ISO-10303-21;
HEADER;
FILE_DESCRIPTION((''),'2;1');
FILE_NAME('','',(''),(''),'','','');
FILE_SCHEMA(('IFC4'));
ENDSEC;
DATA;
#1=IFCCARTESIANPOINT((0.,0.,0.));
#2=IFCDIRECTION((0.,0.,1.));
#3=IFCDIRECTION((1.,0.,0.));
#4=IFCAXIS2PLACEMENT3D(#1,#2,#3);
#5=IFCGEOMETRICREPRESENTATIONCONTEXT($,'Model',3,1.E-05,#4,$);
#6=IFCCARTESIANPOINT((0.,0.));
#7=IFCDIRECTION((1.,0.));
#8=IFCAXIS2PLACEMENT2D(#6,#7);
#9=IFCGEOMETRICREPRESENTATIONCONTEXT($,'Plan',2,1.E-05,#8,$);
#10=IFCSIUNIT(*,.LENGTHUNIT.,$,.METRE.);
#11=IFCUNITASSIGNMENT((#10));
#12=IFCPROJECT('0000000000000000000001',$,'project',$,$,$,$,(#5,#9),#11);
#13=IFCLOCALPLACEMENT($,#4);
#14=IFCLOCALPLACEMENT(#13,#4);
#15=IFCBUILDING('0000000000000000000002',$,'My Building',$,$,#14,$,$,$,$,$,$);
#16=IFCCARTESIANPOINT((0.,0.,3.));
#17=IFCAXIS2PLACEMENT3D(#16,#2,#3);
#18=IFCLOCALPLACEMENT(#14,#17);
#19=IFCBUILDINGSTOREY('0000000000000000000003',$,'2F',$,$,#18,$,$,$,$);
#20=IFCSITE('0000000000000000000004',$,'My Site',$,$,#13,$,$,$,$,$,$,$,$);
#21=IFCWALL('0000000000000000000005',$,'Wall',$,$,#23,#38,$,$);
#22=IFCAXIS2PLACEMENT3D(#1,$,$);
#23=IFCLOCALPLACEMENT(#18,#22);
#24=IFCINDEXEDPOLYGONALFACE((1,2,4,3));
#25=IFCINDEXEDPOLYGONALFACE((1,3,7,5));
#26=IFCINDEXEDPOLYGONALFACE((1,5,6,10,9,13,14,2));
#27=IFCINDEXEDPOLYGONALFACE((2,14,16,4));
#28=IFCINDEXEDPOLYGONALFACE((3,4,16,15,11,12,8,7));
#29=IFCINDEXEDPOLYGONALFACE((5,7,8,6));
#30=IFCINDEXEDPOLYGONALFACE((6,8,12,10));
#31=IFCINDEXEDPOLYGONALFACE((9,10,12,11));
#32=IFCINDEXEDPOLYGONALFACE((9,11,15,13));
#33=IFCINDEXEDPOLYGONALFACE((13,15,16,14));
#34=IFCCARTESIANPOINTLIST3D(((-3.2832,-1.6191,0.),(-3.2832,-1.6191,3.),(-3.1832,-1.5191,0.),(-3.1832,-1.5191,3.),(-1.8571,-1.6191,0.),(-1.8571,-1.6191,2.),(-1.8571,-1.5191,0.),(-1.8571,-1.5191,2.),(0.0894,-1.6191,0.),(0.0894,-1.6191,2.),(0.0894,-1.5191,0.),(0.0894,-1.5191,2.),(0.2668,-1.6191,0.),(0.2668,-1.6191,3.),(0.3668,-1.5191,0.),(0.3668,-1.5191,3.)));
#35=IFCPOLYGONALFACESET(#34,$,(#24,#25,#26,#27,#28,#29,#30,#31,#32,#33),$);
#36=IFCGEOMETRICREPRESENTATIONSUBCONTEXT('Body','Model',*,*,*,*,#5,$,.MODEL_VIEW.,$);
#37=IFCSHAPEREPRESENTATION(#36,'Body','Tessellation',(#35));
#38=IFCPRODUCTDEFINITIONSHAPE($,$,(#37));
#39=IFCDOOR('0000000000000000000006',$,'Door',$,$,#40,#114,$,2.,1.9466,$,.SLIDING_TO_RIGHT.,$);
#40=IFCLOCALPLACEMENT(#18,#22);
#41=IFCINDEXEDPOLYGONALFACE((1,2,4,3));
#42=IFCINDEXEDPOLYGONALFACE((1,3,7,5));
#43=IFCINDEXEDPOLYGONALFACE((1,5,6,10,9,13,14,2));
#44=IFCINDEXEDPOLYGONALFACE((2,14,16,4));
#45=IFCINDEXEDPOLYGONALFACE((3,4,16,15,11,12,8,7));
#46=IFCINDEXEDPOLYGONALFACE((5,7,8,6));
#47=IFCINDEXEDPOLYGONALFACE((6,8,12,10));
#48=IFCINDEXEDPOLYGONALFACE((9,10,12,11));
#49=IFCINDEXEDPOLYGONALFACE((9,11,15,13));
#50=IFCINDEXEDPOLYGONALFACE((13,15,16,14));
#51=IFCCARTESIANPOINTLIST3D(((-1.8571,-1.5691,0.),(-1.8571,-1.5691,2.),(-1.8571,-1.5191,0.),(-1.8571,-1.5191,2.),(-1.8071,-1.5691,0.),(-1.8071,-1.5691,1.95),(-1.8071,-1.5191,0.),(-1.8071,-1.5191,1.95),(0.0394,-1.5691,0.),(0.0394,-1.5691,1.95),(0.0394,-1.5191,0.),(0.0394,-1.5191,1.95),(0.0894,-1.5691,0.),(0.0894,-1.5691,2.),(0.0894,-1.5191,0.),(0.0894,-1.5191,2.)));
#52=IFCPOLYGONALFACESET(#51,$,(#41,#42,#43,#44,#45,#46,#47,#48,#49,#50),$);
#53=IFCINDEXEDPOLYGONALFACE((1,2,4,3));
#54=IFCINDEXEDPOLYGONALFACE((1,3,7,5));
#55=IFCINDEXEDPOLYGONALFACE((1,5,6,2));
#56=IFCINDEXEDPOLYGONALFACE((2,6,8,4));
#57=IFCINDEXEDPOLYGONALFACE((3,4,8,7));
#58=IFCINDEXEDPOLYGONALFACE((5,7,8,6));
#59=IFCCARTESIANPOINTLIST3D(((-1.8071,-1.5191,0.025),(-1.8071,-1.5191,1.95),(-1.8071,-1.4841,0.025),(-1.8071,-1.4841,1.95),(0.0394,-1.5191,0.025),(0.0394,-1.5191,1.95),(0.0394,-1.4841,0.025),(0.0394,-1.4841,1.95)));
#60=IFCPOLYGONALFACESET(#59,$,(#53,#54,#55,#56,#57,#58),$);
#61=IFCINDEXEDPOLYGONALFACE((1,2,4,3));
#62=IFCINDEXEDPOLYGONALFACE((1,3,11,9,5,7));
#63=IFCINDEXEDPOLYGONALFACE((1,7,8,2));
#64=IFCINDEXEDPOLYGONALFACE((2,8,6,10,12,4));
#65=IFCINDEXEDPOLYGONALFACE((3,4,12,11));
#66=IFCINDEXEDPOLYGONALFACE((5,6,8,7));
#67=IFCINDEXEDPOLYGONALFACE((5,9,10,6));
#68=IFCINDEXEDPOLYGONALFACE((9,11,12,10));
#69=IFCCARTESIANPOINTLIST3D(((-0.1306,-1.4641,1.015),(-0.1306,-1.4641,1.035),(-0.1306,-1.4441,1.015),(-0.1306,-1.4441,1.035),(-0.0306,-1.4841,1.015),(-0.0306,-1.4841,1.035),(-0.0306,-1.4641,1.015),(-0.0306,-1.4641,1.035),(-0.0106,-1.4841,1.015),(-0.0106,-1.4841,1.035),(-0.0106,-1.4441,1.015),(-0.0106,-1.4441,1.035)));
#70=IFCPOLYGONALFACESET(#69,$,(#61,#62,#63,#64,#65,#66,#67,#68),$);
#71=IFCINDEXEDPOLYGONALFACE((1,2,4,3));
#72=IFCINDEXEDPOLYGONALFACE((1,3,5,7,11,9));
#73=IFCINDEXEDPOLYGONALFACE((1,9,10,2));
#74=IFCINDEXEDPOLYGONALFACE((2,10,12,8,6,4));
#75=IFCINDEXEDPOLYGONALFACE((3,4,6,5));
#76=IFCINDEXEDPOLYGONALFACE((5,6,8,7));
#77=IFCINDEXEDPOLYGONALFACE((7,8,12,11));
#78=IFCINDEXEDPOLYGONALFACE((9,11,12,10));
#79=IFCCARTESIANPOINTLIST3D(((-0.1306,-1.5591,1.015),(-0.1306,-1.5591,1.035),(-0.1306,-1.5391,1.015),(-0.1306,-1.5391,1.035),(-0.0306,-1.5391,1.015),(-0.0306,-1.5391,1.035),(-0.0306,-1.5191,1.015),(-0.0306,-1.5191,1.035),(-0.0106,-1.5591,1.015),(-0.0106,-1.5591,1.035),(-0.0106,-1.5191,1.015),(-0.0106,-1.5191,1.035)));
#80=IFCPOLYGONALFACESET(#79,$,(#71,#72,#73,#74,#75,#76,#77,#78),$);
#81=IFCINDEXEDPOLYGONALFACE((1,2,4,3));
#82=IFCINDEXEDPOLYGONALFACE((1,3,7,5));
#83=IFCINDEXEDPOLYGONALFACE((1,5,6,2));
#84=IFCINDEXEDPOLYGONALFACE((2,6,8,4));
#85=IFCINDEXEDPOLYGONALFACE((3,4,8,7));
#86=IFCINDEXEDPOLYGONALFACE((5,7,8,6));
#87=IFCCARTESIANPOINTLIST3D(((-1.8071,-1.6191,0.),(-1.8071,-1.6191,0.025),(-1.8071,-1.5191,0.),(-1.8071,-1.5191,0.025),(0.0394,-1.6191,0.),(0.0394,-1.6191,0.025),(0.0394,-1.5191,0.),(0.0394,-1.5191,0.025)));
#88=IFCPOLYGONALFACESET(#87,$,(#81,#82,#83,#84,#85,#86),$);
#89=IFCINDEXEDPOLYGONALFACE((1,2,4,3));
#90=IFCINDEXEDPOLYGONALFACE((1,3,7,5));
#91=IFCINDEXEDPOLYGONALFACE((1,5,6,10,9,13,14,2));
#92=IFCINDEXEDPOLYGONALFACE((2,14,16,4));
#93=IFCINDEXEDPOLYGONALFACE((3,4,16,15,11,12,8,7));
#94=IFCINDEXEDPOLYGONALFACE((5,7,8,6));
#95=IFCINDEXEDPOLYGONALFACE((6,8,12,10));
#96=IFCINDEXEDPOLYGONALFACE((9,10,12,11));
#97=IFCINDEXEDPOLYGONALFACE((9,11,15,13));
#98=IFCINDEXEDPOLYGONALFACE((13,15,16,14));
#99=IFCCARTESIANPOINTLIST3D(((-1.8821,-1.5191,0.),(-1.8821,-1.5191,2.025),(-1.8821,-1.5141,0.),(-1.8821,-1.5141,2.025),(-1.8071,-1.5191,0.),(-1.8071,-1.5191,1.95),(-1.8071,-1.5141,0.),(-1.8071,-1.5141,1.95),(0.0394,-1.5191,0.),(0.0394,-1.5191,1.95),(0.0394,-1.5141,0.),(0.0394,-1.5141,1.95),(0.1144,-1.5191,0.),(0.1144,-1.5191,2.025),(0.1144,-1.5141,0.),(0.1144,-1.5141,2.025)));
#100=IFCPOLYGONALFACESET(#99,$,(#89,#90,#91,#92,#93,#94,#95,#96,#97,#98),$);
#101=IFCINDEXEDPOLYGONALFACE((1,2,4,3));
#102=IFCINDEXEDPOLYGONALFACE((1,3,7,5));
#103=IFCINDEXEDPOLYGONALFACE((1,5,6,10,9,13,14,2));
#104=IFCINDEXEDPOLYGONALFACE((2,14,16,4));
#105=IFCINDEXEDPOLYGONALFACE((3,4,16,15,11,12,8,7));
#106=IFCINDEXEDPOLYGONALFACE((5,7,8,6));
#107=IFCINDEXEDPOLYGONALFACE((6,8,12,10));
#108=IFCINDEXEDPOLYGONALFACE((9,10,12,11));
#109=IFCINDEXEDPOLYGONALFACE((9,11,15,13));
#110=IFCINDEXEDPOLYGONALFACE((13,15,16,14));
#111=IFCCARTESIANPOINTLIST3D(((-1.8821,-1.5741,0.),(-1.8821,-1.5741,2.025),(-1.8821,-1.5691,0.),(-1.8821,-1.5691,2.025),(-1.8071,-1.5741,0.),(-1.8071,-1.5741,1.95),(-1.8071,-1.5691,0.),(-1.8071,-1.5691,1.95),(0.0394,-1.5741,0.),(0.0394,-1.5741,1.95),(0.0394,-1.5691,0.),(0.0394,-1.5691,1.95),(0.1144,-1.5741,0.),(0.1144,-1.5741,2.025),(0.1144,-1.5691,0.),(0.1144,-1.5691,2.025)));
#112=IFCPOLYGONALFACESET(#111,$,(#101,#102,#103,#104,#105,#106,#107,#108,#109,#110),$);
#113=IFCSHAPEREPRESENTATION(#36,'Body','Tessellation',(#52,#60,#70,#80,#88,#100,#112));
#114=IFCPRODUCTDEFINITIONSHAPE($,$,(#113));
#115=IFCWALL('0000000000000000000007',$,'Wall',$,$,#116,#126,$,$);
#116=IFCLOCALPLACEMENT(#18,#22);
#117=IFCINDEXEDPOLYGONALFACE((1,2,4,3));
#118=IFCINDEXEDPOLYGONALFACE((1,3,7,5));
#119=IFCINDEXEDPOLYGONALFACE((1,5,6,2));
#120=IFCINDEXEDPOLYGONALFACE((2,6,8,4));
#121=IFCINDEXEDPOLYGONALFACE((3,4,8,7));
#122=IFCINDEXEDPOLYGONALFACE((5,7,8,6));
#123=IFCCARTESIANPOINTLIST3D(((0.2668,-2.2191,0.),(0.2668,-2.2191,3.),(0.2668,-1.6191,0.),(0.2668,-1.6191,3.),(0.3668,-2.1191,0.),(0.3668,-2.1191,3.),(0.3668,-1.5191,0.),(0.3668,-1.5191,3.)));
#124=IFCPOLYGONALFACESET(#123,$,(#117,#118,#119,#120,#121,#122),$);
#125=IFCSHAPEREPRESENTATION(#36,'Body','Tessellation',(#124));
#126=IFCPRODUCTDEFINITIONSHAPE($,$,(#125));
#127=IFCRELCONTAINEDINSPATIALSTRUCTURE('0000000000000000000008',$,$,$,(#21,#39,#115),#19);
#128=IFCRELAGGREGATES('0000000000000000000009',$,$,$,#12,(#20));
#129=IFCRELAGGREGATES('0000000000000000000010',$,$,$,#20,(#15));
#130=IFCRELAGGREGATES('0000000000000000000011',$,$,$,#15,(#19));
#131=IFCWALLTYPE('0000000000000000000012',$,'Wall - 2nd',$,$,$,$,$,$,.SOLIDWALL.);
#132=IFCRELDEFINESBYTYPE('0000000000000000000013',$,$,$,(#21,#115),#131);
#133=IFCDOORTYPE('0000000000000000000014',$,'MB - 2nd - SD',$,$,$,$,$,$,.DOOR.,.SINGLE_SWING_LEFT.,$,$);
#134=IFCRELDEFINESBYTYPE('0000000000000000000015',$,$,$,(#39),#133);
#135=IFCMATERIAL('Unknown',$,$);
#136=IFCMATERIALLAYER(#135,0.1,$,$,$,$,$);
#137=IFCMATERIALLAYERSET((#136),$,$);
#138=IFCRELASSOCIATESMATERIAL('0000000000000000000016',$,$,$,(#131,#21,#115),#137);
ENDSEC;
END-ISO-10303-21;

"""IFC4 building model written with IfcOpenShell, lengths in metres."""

from ifc_helpers import new_model, entity, si_unit, frame, origin_with_axes, origin_2d_with_axis, place, context, subcontext, project, spatial, line, indexed_curve, outline, extrude, shape, source, transform, mapped, material, layer, layer_set, layer_usage, type_object, type_shapes, element, fill, save


model = new_model("IFC4")

# Units and contexts
model_context = context("Model", 3, precision=1e-05, world=origin_with_axes())
plan_context = context("Plan", 2, precision=1e-05, world=origin_2d_with_axis())
body_context_1 = subcontext(model_context, "Body", "Model", "MODEL_VIEW")
body_context_2 = subcontext(plan_context, "Body", "Plan", "PLAN_VIEW")
ifc_project = project(units=[si_unit("LENGTHUNIT", "METRE")], contexts=[model_context, plan_context])

# Site, building, storey
site_placement = place(None, origin_with_axes())
site = spatial("IfcSite", under=ifc_project, at=site_placement, Name="My Site")
building_placement = place(site_placement, origin_with_axes())
building = spatial("IfcBuilding", under=site, at=building_placement, Name="My Building")
storey_placement = place(building_placement, frame((0.0, 0.0, 3.0), z_axis=(0.0, 0.0, 1.0), x_axis=(1.0, 0.0, 0.0)))
storey = spatial("IfcBuildingStorey", under=building, at=storey_placement, Name="2F")

# Shared definitions
ifc_material = material(Name="Unknown")

# Shared definitions
ifc_layer_1 = layer(ifc_material, 0.1)
ifc_layer_set_1 = layer_set([ifc_layer_1])
wall_type = type_object("IfcWallType", Name="Wall - 2nd", PredefinedType="SOLIDWALL", material=ifc_layer_set_1)

# Wall, opening, door
ifc_layer_usage_1 = layer_usage(ifc_layer_set_1, "AXIS2", "POSITIVE", 0.0)
wall_1_placement = place(storey_placement, frame((-3.2832, -1.6191, 0.0), z_axis=(0.0, 0.0, 1.0), x_axis=(1.0, 0.0, 0.0)))
wall_1 = element("IfcWall", 1, at=wall_1_placement, inside=storey, type_object=wall_type, material=ifc_layer_usage_1, Name="Wall", context=body_context_1, shape_type="SweptSolid", body=[
    extrude(outline(indexed_curve([(0.0, 0.0), (0.1, 0.1), (3.65, 0.1), (3.55, 0.0)], segments=[line(1, 2, 3, 4, 1)])), origin_with_axes(), (0.0, 0.0, 1.0), 3.0),
])
shared_shape_1 = source(origin_with_axes(), body_context_1, "Body", "SweptSolid", [
    extrude(outline(indexed_curve([(0.0, 0.0), (1.9466, 0.0), (1.9466, 2.0), (0.0, 2.0)], segments=[line(1, 2, 3, 4, 1)])), frame((0.0, -0.6, 0.0), z_axis=(0.0, -1.0, 0.0), x_axis=(1.0, 0.0, 0.0)), (0.0, 0.0, -1.0), 1.2),
])
opening_1_placement = place(wall_1_placement, frame((3.3726, 0.1, 0.0), z_axis=(0.0, 0.0, 1.0), x_axis=(-1.0, 0.0, 0.0)))
opening_1 = element("IfcOpeningElement", 2, at=opening_1_placement, cuts=wall_1, PredefinedType="OPENING", context=body_context_1, shape_type="MappedRepresentation", body=[
    mapped(shared_shape_1, transform((0.0, 0.0, 0.0), x_axis=(1.0, 0.0, 0.0), y_axis=(0.0, 1.0, 0.0), z_axis=(0.0, 0.0, 1.0), scale=1.0)),
])
door_type_1 = type_object("IfcDoorType", Name="MB - 2nd - SD", OperationType="SINGLE_SWING_LEFT", PredefinedType="DOOR")
shared_shape_2 = source(origin_with_axes(), body_context_1, "Body", "SweptSolid", [
    extrude(outline(indexed_curve([(0.0, 0.0), (0.0, 2.0), (1.9466, 2.0), (1.9466, 0.0), (1.8966, 0.0), (1.8966, 1.95), (0.05, 1.95), (0.05, 0.0)], segments=[line(1, 2, 3, 4, 5, 6, 7, 8, 1)])), frame((0.0, 0.0, 0.0), z_axis=(0.0, -1.0, 0.0), x_axis=(1.0, 0.0, 0.0)), (0.0, 0.0, -1.0), 0.05),
    extrude(outline(indexed_curve([(0.0, 0.0), (1.8466, 0.0), (1.8466, 0.035), (0.0, 0.035)], segments=[line(1, 2, 3, 4, 1)])), frame((0.05, -0.035, 0.025), z_axis=(0.0, 0.0, 1.0), x_axis=(1.0, 0.0, 0.0)), (0.0, 0.0, 1.0), 1.925),
    extrude(outline(indexed_curve([(0.0, 0.0), (0.0, -0.04), (0.12, -0.04), (0.12, -0.02), (0.02, -0.02), (0.02, 0.0)], segments=[line(1, 2, 3, 4, 5, 6, 1)])), frame((0.1, -0.035, 1.015), z_axis=(0.0, 0.0, 1.0), x_axis=(1.0, 0.0, 0.0)), (0.0, 0.0, 1.0), 0.02),
    extrude(outline(indexed_curve([(0.0, 0.0), (0.0, 0.04), (0.12, 0.04), (0.12, 0.02), (0.02, 0.02), (0.02, 0.0)], segments=[line(1, 2, 3, 4, 5, 6, 1)])), frame((0.1, 0.0, 1.015), z_axis=(0.0, 0.0, 1.0), x_axis=(1.0, 0.0, 0.0)), (0.0, 0.0, 1.0), 0.02),
    extrude(outline(indexed_curve([(0.0, 0.0), (1.8466, 0.0), (1.8466, 0.1), (0.0, 0.1)], segments=[line(1, 2, 3, 4, 1)])), frame((0.05, 0.0, 0.0), z_axis=(0.0, 0.0, 1.0), x_axis=(1.0, 0.0, 0.0)), (0.0, 0.0, 1.0), 0.025),
    extrude(outline(indexed_curve([(0.0, 0.0), (0.0, 2.025), (1.9966, 2.025), (1.9966, 0.0), (1.9216, 0.0), (1.9216, 1.95), (0.075, 1.95), (0.075, 0.0)], segments=[line(1, 2, 3, 4, 5, 6, 7, 8, 1)])), frame((-0.025, -0.005, 0.0), z_axis=(0.0, -1.0, 0.0), x_axis=(1.0, 0.0, 0.0)), (0.0, 0.0, -1.0), 0.005),
    extrude(outline(indexed_curve([(0.0, 0.0), (0.0, 2.025), (1.9966, 2.025), (1.9966, 0.0), (1.9216, 0.0), (1.9216, 1.95), (0.075, 1.95), (0.075, 0.0)], segments=[line(1, 2, 3, 4, 5, 6, 7, 8, 1)])), frame((-0.025, 0.05, 0.0), z_axis=(0.0, -1.0, 0.0), x_axis=(1.0, 0.0, 0.0)), (0.0, 0.0, -1.0), 0.005),
])
shared_shape_3 = source(origin_with_axes(), body_context_2, "Body", "Curve2D", [
    entity("IfcIndexedPolyCurve", entity("IfcCartesianPointList2D", [[0.0, 0.0], [0.05, 0.0], [0.05, 0.05], [0.0, 0.05]]), [entity("IfcLineIndex", [1, 2, 3, 4, 1])]),
    entity("IfcIndexedPolyCurve", entity("IfcCartesianPointList2D", [[1.9466, 0.0], [1.8966, 0.0], [1.8966, 0.05], [1.9466, 0.05]]), [entity("IfcLineIndex", [1, 2, 3, 4, 1])]),
    entity("IfcIndexedPolyCurve", entity("IfcCartesianPointList2D", [[2.8198, -0.035], [0.9733, -0.035], [0.9733, 0.0], [2.8198, 0.0]]), [entity("IfcLineIndex", [1, 2, 3, 4, 1])]),
])
type_shapes(door_type_1, [shared_shape_2, shared_shape_3])
door_1_placement = place(opening_1_placement, origin_with_axes())
door_1 = element("IfcDoor", 3, at=door_1_placement, inside=storey, type_object=door_type_1, Name="Door", OperationType="SLIDING_TO_RIGHT", OverallHeight=2.0, OverallWidth=1.9466, shapes=[
    shape(body_context_1, "Body", "MappedRepresentation", [mapped(shared_shape_2, transform((0.0, 0.0, 0.0), x_axis=(1.0, 0.0, 0.0), y_axis=(0.0, 1.0, 0.0), z_axis=(0.0, 0.0, 1.0), scale=1.0))]),
    shape(body_context_2, "Body", "MappedRepresentation", [mapped(shared_shape_3, transform((0.0, 0.0, 0.0), x_axis=(1.0, 0.0, 0.0), y_axis=(0.0, 1.0, 0.0), z_axis=(0.0, 0.0, 1.0), scale=1.0))]),
])
fill(opening_1, door_1)

# Wall
ifc_layer_usage_2 = layer_usage(ifc_layer_set_1, "AXIS2", "POSITIVE", 0.0)
wall_2_placement = place(storey_placement, frame((0.2668, -1.6191, 0.0), z_axis=(0.0, 0.0, 1.0), x_axis=(0.0, -1.0, 0.0)))
element("IfcWall", 4, at=wall_2_placement, inside=storey, type_object=wall_type, material=ifc_layer_usage_2, Name="Wall", context=body_context_1, shape_type="SweptSolid", body=[
    extrude(outline(indexed_curve([(0.0, 0.0), (-0.1, 0.1), (0.5, 0.1), (0.6, 0.0)], segments=[line(1, 2, 3, 4, 1)])), origin_with_axes(), (0.0, 0.0, 1.0), 3.0),
])

save(model, "model.ifc")
